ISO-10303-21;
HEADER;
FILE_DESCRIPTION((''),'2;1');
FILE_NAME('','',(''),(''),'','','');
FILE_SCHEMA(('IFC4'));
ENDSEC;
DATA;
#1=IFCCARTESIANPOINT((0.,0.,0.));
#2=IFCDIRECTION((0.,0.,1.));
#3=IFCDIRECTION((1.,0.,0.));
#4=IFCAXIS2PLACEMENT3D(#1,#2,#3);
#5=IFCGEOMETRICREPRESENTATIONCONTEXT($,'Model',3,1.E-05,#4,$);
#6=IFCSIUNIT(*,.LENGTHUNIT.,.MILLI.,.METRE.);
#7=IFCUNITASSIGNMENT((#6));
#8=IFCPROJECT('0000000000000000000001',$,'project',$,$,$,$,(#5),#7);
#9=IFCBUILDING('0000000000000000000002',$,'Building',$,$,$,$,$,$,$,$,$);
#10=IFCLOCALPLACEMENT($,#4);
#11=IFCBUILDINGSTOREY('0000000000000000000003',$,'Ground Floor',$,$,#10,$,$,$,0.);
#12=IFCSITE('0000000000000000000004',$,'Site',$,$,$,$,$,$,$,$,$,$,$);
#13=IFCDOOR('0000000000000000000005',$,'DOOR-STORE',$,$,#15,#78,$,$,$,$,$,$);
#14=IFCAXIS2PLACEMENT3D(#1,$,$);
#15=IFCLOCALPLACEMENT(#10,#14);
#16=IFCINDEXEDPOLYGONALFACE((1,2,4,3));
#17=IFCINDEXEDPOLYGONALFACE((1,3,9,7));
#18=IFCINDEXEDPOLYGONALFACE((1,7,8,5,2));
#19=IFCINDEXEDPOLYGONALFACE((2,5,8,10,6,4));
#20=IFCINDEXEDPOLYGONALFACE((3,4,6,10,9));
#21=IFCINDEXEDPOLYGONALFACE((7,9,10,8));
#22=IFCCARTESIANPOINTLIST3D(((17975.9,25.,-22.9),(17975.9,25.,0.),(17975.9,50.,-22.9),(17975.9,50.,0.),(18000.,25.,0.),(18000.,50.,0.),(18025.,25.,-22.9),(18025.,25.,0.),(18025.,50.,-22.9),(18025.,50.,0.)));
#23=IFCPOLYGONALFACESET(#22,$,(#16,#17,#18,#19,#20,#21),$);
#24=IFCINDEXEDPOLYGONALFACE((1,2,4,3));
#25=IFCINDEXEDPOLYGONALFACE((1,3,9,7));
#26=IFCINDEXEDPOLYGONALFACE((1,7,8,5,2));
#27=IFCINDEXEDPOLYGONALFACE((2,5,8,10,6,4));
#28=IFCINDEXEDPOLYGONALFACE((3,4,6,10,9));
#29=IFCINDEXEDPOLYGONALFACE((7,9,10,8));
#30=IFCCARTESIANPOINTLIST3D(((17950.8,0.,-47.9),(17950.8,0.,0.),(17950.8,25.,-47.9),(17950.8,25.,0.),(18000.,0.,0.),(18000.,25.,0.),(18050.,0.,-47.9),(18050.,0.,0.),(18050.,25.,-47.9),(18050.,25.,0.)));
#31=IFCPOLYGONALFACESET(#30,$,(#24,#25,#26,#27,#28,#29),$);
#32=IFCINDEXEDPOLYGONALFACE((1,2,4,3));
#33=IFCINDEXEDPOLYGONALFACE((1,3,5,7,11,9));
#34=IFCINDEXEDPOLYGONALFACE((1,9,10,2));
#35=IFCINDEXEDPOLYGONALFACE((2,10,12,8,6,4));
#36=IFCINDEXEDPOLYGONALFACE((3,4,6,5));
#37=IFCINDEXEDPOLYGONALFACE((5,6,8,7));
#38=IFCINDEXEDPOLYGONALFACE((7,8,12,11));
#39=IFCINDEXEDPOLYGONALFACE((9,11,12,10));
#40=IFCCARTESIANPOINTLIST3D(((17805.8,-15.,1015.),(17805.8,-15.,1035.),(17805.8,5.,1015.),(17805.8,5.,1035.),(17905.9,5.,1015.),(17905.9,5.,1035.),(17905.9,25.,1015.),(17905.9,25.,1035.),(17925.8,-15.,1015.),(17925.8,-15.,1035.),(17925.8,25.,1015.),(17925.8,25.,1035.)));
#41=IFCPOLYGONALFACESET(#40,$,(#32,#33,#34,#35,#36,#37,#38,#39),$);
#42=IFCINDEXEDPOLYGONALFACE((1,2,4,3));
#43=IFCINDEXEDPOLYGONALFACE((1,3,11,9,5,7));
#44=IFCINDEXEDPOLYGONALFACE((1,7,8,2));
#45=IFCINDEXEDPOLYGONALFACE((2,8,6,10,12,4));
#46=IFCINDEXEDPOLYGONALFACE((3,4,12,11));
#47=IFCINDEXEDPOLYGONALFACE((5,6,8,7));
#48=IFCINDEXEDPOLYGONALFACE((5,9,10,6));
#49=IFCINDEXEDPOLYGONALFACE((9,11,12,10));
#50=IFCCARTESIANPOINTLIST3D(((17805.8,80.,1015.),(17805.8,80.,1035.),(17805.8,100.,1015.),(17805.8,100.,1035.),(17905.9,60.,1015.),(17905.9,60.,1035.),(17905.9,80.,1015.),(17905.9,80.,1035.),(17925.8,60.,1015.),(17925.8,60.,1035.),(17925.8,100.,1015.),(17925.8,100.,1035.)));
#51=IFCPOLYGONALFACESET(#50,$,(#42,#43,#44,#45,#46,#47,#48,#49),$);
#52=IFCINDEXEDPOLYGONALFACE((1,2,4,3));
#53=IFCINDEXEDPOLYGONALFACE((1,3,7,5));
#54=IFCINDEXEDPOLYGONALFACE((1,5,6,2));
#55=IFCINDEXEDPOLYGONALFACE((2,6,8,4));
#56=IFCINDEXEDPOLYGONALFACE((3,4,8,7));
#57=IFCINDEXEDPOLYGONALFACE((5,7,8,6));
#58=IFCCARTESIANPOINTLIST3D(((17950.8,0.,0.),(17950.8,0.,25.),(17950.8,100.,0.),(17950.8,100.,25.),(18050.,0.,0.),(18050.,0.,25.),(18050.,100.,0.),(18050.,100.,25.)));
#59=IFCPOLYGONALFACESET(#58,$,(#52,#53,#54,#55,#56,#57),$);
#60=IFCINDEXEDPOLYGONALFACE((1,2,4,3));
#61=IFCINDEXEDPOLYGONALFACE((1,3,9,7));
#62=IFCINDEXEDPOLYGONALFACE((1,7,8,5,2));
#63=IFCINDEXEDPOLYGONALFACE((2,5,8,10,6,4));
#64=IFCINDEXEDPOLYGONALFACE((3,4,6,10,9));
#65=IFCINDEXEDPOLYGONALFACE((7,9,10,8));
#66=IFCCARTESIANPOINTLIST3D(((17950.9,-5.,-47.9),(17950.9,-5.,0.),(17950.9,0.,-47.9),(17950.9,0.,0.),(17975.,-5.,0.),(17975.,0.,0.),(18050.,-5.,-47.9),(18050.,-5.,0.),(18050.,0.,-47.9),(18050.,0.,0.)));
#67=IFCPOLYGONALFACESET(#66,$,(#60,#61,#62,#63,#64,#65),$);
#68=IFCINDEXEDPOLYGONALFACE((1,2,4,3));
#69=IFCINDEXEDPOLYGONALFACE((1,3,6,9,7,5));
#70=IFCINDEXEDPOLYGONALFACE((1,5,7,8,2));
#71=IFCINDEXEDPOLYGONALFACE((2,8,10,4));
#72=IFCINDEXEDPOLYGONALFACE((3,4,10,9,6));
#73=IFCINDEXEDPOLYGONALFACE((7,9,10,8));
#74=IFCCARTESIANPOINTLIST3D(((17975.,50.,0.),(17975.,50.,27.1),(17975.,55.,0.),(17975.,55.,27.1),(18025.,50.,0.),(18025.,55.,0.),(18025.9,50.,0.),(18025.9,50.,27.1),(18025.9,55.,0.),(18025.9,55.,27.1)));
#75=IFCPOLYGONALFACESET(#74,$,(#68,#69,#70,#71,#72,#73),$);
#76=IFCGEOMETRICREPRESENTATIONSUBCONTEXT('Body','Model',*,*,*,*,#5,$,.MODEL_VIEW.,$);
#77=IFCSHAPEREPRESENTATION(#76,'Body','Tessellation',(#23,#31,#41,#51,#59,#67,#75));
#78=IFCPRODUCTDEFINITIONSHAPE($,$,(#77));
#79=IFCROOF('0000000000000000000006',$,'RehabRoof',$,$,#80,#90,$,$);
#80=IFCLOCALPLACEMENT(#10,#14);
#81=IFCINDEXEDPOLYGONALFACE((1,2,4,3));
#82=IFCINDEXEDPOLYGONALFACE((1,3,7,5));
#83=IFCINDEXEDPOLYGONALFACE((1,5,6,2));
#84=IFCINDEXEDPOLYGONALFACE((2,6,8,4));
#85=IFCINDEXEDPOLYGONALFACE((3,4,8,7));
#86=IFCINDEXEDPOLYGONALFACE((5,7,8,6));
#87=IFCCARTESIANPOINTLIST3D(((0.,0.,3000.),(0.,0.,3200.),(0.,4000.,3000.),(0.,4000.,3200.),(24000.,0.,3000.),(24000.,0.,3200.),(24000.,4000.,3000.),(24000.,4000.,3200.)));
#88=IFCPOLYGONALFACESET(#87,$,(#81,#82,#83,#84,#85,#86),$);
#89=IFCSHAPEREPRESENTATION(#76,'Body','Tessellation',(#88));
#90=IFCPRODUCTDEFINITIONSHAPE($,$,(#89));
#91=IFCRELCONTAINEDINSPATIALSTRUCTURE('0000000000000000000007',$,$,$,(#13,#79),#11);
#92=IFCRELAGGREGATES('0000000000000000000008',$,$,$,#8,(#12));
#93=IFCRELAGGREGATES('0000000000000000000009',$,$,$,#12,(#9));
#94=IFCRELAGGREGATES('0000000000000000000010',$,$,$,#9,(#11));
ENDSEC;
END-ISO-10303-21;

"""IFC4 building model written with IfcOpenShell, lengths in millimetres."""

from ifc_helpers import new_model, si_unit, frame, origin_with_axes, place, context, subcontext, project, spatial, line, indexed_curve, outline, extrude, element, save


model = new_model("IFC4")

# Units and contexts
model_context = context("Model", 3, precision=1e-05, world=origin_with_axes())
body_context = subcontext(model_context, "Body", "Model", "MODEL_VIEW")
ifc_project = project(units=[si_unit("LENGTHUNIT", "METRE", prefix="MILLI")], contexts=[model_context])

# Site, building, storey
site = spatial("IfcSite", under=ifc_project, Name="Site")
building = spatial("IfcBuilding", under=site, Name="Building")
storey_placement = place(None, origin_with_axes())
storey = spatial("IfcBuildingStorey", under=building, at=storey_placement, Name="Ground Floor", Elevation=0.0)

# Door
door_1_placement = place(storey_placement, frame((18000.0, 0.0, 0.0), z_axis=(0.0, 0.0, 1.0), x_axis=(1.0, 0.0, 0.0)))
element("IfcDoor", 1, at=door_1_placement, inside=storey, Name="DOOR-STORE", context=body_context, shape_type="SweptSolid", body=[
    extrude(outline(indexed_curve([(0.0, 0.0), (0.0, 2.1), (0.8, 2.1), (0.8, 0.0), (-24.1, 0.0), (-24.1, -22.9), (25.0, -22.9), (25.0, 0.0)], segments=[line(1, 2, 3, 4, 5, 6, 7, 8, 1)])), frame((0.0, 25.0, 0.0), z_axis=(0.0, -1.0, 0.0), x_axis=(1.0, 0.0, 0.0)), (0.0, 0.0, -1.0), 25.0),
    extrude(outline(indexed_curve([(0.0, 0.0), (0.0, 2.1), (0.8, 2.1), (0.8, 0.0), (-49.1, 0.0), (-49.1, -47.9), (50.0, -47.9), (50.0, 0.0)], segments=[line(1, 2, 3, 4, 5, 6, 7, 8, 1)])), frame((0.0, 0.0, 0.0), z_axis=(0.0, -1.0, 0.0), x_axis=(1.0, 0.0, 0.0)), (0.0, 0.0, -1.0), 25.0),
    extrude(outline(indexed_curve([(0.0, 0.0), (-49.1, 0.0), (-49.1, 35.0), (0.0, 35.0)], segments=[line(1, 2, 3, 4, 1)])), frame((25.0, 25.0, 25.0), z_axis=(0.0, 0.0, 1.0), x_axis=(1.0, 0.0, 0.0)), (0.0, 0.0, 1.0), -47.9),
    extrude(outline(indexed_curve([(0.0, 0.0), (0.0, -40.0), (-120.0, -40.0), (-120.0, -20.0), (-20.0, -20.0), (-20.0, 0.0)], segments=[line(1, 2, 3, 4, 5, 6, 1)])), frame((-74.2, 25.0, 1015.0), z_axis=(0.0, 0.0, 1.0), x_axis=(1.0, 0.0, 0.0)), (0.0, 0.0, 1.0), 20.0),
    extrude(outline(indexed_curve([(0.0, 0.0), (0.0, 40.0), (-120.0, 40.0), (-120.0, 20.0), (-20.0, 20.0), (-20.0, 0.0)], segments=[line(1, 2, 3, 4, 5, 6, 1)])), frame((-74.2, 60.0, 1015.0), z_axis=(0.0, 0.0, 1.0), x_axis=(1.0, 0.0, 0.0)), (0.0, 0.0, 1.0), 20.0),
    extrude(outline(indexed_curve([(0.0, 0.0), (-99.2, 0.0), (-99.2, 100.0), (0.0, 100.0)], segments=[line(1, 2, 3, 4, 1)])), frame((50.0, 0.0, 0.0), z_axis=(0.0, 0.0, 1.0), x_axis=(1.0, 0.0, 0.0)), (0.0, 0.0, 1.0), 25.0),
    extrude(outline(indexed_curve([(0.0, 0.0), (0.0, 27.1), (50.9, 27.1), (50.9, 0.0), (-24.1, 0.0), (-24.1, -47.9), (75.0, -47.9), (75.0, 0.0)], segments=[line(1, 2, 3, 4, 5, 6, 7, 8, 1)])), frame((-25.0, -5.0, 0.0), z_axis=(0.0, -1.0, 0.0), x_axis=(1.0, 0.0, 0.0)), (0.0, 0.0, -1.0), 5.0),
    extrude(outline(indexed_curve([(0.0, 0.0), (0.0, 27.1), (50.9, 27.1), (50.9, 0.0), (0.9, 0.0), (0.9, -22.9), (50.0, -22.9), (50.0, 0.0)], segments=[line(1, 2, 3, 4, 5, 6, 7, 8, 1)])), frame((-25.0, 50.0, 0.0), z_axis=(0.0, -1.0, 0.0), x_axis=(1.0, 0.0, 0.0)), (0.0, 0.0, -1.0), 5.0),
])

# Roof
roof_placement = place(storey_placement, frame((0.0, 0.0, 3000.0), z_axis=(0.0, 0.0, 1.0), x_axis=(1.0, 0.0, 0.0)))
element("IfcRoof", 2, at=roof_placement, inside=storey, Name="RehabRoof", context=body_context, shape_type="SweptSolid", body=[
    extrude(outline(indexed_curve([(0.0, 0.0), (24000.0, 0.0), (24000.0, 4000.0), (0.0, 4000.0), (0.0, 0.0)])), None, (0.0, 0.0, 1.0), 200.0),
])

save(model, "model.ifc")
